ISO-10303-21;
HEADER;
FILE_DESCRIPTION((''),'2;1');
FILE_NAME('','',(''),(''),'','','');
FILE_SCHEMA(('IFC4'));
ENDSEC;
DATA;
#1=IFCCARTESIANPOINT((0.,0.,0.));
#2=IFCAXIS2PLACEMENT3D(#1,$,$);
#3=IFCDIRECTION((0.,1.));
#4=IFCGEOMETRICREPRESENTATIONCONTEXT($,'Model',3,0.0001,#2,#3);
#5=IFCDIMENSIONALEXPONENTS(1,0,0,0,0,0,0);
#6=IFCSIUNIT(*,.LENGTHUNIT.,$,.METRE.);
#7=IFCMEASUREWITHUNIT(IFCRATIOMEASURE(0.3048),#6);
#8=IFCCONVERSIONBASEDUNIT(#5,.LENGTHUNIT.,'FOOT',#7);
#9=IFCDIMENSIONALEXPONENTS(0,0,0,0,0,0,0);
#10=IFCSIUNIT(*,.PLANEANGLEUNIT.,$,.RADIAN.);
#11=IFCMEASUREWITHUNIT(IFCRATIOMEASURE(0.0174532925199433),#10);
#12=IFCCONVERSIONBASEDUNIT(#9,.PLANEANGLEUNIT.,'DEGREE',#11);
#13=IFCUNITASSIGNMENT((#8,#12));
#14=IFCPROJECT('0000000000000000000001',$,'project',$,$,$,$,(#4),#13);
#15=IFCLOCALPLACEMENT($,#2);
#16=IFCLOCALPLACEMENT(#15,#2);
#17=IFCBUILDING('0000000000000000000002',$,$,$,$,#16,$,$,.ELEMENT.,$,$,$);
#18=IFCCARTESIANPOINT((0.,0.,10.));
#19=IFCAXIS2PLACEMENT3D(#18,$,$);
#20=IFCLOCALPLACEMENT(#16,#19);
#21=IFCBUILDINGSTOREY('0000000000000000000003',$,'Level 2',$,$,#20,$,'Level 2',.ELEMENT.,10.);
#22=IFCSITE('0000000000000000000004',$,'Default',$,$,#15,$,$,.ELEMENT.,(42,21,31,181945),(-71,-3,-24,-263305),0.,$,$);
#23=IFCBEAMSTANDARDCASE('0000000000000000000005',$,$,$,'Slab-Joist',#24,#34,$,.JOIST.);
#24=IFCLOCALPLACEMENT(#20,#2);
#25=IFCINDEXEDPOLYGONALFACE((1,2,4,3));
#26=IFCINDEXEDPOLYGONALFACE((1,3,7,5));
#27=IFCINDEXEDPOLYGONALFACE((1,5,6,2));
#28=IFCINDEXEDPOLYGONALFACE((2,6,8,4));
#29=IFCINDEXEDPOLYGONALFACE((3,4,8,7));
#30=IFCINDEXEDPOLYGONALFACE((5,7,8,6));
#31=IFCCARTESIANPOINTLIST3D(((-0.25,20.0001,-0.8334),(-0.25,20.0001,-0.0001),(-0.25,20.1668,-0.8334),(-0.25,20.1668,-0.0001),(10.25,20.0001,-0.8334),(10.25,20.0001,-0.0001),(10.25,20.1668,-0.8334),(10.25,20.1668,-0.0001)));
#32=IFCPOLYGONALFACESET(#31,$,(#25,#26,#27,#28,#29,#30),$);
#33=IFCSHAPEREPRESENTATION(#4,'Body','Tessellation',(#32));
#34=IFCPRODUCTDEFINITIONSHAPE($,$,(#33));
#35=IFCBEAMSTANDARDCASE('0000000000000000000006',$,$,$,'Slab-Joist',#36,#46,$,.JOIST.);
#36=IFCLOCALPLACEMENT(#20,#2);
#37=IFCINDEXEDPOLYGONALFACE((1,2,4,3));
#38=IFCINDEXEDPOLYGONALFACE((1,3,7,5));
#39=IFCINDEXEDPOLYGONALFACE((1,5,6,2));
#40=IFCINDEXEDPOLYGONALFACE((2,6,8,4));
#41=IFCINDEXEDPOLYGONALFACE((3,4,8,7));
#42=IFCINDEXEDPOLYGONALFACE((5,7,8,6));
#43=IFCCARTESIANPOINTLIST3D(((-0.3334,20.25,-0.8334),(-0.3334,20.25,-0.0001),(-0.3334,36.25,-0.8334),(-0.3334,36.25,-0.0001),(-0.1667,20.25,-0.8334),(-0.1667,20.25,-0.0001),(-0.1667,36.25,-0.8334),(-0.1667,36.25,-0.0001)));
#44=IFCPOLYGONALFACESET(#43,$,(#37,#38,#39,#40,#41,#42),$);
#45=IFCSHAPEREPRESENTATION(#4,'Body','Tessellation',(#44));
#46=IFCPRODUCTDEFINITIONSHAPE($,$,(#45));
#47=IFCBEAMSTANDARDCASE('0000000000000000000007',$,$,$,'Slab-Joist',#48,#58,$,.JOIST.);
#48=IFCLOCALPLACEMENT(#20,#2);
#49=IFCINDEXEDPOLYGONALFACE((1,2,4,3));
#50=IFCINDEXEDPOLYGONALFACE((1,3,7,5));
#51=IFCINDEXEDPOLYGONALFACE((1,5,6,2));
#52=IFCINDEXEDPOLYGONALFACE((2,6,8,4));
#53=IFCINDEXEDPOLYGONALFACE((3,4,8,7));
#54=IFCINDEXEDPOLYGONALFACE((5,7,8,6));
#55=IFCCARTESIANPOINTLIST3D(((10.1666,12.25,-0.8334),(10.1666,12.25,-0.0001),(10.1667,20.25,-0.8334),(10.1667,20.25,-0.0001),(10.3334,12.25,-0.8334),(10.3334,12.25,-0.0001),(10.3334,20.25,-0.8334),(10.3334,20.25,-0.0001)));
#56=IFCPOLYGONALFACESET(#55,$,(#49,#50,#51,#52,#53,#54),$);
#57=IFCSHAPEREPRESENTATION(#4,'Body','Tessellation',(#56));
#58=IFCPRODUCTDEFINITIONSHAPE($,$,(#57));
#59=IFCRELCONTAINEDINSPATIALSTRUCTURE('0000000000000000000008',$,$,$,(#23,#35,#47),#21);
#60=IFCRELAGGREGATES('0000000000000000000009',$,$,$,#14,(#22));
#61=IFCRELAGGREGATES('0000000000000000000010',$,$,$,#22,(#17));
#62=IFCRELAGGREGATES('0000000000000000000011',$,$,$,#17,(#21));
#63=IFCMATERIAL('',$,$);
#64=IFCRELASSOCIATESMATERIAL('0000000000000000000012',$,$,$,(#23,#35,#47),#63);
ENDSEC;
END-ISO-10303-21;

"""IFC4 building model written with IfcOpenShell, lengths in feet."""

from ifc_helpers import new_model, entity, si_unit, converted_unit, direction, frame, origin, origin_with_axes, place, context, project, spatial, rectangle, extrude, material, element, save


model = new_model("IFC4")

# Units and contexts
model_context = context("Model", 3, precision=0.0001, world=origin(), true_north=direction((0.0, 1.0)))
ifc_project = project(units=[converted_unit("LENGTHUNIT", "FOOT", entity("IfcRatioMeasure", 0.3048), si_unit("LENGTHUNIT", "METRE"), dimensions=[1, 0, 0, 0, 0, 0, 0]), converted_unit("PLANEANGLEUNIT", "DEGREE", entity("IfcRatioMeasure", 0.0174532925199433), si_unit("PLANEANGLEUNIT", "RADIAN"), dimensions=[0, 0, 0, 0, 0, 0, 0])], contexts=[model_context])

# Site, building, storey
site_placement = place(None, origin())
site = spatial("IfcSite", under=ifc_project, at=site_placement, Name="Default", CompositionType="ELEMENT", RefLatitude=(42, 21, 31, 181945), RefLongitude=(-71, -3, -24, -263305), RefElevation=0.0)
building_placement = place(site_placement, origin())
building = spatial("IfcBuilding", under=site, at=building_placement, CompositionType="ELEMENT")
storey_placement = place(building_placement, frame((0.0, 0.0, 10.0)))
storey = spatial("IfcBuildingStorey", under=building, at=storey_placement, Name="Level 2", LongName="Level 2", CompositionType="ELEMENT", Elevation=10.0)

# Beams
ifc_material = material(Name="")
placement_1 = place(storey_placement, frame((-0.25, -0.25, 0.0), z_axis=(0.0, 0.0, 1.0), x_axis=(1.0, 0.0, 0.0)))
beam_1_placement = place(placement_1, frame((0.0, 20.3334, -0.4167), z_axis=(1.0, 0.0, 0.0), x_axis=(0.0, 1.0, 0.0)))
element("IfcBeamStandardCase", 1, at=beam_1_placement, inside=storey, material=ifc_material, ObjectType="Slab-Joist", PredefinedType="JOIST", context=model_context, shape_type="SweptSolid", body=[
    extrude(rectangle(XDim=0.1667, YDim=0.8333), origin_with_axes(), (0.0, 0.0, 1.0), 10.5),
])
placement_2 = place(storey_placement, frame((-0.25, 20.25, 0.0), z_axis=(0.0, 0.0, 1.0), x_axis=(1.0, 0.0, 0.0)))
beam_2_placement = place(placement_2, frame((0.0, 0.0, -0.4167), z_axis=(0.0, 1.0, 0.0), x_axis=(-1.0, 0.0, 0.0)))
element("IfcBeamStandardCase", 2, at=beam_2_placement, inside=storey, material=ifc_material, ObjectType="Slab-Joist", PredefinedType="JOIST", context=model_context, shape_type="SweptSolid", body=[
    extrude(rectangle(XDim=0.1667, YDim=0.8333), origin_with_axes(), (0.0, 0.0, 1.0), 16.0),
])
placement_3 = place(storey_placement, frame((10.25, 12.25, 0.0), z_axis=(0.0, 0.0, 1.0), x_axis=(1.0, 0.0, 0.0)))
beam_3_placement = place(placement_3, frame((0.0, 0.0, -0.4167), z_axis=(0.0, 1.0, 0.0), x_axis=(-1.0, 0.0, 0.0)))
element("IfcBeamStandardCase", 3, at=beam_3_placement, inside=storey, material=ifc_material, ObjectType="Slab-Joist", PredefinedType="JOIST", context=model_context, shape_type="SweptSolid", body=[
    extrude(rectangle(XDim=0.1667, YDim=0.8333), origin_with_axes(), (0.0, 0.0, 1.0), 8.0),
])

save(model, "model.ifc")
